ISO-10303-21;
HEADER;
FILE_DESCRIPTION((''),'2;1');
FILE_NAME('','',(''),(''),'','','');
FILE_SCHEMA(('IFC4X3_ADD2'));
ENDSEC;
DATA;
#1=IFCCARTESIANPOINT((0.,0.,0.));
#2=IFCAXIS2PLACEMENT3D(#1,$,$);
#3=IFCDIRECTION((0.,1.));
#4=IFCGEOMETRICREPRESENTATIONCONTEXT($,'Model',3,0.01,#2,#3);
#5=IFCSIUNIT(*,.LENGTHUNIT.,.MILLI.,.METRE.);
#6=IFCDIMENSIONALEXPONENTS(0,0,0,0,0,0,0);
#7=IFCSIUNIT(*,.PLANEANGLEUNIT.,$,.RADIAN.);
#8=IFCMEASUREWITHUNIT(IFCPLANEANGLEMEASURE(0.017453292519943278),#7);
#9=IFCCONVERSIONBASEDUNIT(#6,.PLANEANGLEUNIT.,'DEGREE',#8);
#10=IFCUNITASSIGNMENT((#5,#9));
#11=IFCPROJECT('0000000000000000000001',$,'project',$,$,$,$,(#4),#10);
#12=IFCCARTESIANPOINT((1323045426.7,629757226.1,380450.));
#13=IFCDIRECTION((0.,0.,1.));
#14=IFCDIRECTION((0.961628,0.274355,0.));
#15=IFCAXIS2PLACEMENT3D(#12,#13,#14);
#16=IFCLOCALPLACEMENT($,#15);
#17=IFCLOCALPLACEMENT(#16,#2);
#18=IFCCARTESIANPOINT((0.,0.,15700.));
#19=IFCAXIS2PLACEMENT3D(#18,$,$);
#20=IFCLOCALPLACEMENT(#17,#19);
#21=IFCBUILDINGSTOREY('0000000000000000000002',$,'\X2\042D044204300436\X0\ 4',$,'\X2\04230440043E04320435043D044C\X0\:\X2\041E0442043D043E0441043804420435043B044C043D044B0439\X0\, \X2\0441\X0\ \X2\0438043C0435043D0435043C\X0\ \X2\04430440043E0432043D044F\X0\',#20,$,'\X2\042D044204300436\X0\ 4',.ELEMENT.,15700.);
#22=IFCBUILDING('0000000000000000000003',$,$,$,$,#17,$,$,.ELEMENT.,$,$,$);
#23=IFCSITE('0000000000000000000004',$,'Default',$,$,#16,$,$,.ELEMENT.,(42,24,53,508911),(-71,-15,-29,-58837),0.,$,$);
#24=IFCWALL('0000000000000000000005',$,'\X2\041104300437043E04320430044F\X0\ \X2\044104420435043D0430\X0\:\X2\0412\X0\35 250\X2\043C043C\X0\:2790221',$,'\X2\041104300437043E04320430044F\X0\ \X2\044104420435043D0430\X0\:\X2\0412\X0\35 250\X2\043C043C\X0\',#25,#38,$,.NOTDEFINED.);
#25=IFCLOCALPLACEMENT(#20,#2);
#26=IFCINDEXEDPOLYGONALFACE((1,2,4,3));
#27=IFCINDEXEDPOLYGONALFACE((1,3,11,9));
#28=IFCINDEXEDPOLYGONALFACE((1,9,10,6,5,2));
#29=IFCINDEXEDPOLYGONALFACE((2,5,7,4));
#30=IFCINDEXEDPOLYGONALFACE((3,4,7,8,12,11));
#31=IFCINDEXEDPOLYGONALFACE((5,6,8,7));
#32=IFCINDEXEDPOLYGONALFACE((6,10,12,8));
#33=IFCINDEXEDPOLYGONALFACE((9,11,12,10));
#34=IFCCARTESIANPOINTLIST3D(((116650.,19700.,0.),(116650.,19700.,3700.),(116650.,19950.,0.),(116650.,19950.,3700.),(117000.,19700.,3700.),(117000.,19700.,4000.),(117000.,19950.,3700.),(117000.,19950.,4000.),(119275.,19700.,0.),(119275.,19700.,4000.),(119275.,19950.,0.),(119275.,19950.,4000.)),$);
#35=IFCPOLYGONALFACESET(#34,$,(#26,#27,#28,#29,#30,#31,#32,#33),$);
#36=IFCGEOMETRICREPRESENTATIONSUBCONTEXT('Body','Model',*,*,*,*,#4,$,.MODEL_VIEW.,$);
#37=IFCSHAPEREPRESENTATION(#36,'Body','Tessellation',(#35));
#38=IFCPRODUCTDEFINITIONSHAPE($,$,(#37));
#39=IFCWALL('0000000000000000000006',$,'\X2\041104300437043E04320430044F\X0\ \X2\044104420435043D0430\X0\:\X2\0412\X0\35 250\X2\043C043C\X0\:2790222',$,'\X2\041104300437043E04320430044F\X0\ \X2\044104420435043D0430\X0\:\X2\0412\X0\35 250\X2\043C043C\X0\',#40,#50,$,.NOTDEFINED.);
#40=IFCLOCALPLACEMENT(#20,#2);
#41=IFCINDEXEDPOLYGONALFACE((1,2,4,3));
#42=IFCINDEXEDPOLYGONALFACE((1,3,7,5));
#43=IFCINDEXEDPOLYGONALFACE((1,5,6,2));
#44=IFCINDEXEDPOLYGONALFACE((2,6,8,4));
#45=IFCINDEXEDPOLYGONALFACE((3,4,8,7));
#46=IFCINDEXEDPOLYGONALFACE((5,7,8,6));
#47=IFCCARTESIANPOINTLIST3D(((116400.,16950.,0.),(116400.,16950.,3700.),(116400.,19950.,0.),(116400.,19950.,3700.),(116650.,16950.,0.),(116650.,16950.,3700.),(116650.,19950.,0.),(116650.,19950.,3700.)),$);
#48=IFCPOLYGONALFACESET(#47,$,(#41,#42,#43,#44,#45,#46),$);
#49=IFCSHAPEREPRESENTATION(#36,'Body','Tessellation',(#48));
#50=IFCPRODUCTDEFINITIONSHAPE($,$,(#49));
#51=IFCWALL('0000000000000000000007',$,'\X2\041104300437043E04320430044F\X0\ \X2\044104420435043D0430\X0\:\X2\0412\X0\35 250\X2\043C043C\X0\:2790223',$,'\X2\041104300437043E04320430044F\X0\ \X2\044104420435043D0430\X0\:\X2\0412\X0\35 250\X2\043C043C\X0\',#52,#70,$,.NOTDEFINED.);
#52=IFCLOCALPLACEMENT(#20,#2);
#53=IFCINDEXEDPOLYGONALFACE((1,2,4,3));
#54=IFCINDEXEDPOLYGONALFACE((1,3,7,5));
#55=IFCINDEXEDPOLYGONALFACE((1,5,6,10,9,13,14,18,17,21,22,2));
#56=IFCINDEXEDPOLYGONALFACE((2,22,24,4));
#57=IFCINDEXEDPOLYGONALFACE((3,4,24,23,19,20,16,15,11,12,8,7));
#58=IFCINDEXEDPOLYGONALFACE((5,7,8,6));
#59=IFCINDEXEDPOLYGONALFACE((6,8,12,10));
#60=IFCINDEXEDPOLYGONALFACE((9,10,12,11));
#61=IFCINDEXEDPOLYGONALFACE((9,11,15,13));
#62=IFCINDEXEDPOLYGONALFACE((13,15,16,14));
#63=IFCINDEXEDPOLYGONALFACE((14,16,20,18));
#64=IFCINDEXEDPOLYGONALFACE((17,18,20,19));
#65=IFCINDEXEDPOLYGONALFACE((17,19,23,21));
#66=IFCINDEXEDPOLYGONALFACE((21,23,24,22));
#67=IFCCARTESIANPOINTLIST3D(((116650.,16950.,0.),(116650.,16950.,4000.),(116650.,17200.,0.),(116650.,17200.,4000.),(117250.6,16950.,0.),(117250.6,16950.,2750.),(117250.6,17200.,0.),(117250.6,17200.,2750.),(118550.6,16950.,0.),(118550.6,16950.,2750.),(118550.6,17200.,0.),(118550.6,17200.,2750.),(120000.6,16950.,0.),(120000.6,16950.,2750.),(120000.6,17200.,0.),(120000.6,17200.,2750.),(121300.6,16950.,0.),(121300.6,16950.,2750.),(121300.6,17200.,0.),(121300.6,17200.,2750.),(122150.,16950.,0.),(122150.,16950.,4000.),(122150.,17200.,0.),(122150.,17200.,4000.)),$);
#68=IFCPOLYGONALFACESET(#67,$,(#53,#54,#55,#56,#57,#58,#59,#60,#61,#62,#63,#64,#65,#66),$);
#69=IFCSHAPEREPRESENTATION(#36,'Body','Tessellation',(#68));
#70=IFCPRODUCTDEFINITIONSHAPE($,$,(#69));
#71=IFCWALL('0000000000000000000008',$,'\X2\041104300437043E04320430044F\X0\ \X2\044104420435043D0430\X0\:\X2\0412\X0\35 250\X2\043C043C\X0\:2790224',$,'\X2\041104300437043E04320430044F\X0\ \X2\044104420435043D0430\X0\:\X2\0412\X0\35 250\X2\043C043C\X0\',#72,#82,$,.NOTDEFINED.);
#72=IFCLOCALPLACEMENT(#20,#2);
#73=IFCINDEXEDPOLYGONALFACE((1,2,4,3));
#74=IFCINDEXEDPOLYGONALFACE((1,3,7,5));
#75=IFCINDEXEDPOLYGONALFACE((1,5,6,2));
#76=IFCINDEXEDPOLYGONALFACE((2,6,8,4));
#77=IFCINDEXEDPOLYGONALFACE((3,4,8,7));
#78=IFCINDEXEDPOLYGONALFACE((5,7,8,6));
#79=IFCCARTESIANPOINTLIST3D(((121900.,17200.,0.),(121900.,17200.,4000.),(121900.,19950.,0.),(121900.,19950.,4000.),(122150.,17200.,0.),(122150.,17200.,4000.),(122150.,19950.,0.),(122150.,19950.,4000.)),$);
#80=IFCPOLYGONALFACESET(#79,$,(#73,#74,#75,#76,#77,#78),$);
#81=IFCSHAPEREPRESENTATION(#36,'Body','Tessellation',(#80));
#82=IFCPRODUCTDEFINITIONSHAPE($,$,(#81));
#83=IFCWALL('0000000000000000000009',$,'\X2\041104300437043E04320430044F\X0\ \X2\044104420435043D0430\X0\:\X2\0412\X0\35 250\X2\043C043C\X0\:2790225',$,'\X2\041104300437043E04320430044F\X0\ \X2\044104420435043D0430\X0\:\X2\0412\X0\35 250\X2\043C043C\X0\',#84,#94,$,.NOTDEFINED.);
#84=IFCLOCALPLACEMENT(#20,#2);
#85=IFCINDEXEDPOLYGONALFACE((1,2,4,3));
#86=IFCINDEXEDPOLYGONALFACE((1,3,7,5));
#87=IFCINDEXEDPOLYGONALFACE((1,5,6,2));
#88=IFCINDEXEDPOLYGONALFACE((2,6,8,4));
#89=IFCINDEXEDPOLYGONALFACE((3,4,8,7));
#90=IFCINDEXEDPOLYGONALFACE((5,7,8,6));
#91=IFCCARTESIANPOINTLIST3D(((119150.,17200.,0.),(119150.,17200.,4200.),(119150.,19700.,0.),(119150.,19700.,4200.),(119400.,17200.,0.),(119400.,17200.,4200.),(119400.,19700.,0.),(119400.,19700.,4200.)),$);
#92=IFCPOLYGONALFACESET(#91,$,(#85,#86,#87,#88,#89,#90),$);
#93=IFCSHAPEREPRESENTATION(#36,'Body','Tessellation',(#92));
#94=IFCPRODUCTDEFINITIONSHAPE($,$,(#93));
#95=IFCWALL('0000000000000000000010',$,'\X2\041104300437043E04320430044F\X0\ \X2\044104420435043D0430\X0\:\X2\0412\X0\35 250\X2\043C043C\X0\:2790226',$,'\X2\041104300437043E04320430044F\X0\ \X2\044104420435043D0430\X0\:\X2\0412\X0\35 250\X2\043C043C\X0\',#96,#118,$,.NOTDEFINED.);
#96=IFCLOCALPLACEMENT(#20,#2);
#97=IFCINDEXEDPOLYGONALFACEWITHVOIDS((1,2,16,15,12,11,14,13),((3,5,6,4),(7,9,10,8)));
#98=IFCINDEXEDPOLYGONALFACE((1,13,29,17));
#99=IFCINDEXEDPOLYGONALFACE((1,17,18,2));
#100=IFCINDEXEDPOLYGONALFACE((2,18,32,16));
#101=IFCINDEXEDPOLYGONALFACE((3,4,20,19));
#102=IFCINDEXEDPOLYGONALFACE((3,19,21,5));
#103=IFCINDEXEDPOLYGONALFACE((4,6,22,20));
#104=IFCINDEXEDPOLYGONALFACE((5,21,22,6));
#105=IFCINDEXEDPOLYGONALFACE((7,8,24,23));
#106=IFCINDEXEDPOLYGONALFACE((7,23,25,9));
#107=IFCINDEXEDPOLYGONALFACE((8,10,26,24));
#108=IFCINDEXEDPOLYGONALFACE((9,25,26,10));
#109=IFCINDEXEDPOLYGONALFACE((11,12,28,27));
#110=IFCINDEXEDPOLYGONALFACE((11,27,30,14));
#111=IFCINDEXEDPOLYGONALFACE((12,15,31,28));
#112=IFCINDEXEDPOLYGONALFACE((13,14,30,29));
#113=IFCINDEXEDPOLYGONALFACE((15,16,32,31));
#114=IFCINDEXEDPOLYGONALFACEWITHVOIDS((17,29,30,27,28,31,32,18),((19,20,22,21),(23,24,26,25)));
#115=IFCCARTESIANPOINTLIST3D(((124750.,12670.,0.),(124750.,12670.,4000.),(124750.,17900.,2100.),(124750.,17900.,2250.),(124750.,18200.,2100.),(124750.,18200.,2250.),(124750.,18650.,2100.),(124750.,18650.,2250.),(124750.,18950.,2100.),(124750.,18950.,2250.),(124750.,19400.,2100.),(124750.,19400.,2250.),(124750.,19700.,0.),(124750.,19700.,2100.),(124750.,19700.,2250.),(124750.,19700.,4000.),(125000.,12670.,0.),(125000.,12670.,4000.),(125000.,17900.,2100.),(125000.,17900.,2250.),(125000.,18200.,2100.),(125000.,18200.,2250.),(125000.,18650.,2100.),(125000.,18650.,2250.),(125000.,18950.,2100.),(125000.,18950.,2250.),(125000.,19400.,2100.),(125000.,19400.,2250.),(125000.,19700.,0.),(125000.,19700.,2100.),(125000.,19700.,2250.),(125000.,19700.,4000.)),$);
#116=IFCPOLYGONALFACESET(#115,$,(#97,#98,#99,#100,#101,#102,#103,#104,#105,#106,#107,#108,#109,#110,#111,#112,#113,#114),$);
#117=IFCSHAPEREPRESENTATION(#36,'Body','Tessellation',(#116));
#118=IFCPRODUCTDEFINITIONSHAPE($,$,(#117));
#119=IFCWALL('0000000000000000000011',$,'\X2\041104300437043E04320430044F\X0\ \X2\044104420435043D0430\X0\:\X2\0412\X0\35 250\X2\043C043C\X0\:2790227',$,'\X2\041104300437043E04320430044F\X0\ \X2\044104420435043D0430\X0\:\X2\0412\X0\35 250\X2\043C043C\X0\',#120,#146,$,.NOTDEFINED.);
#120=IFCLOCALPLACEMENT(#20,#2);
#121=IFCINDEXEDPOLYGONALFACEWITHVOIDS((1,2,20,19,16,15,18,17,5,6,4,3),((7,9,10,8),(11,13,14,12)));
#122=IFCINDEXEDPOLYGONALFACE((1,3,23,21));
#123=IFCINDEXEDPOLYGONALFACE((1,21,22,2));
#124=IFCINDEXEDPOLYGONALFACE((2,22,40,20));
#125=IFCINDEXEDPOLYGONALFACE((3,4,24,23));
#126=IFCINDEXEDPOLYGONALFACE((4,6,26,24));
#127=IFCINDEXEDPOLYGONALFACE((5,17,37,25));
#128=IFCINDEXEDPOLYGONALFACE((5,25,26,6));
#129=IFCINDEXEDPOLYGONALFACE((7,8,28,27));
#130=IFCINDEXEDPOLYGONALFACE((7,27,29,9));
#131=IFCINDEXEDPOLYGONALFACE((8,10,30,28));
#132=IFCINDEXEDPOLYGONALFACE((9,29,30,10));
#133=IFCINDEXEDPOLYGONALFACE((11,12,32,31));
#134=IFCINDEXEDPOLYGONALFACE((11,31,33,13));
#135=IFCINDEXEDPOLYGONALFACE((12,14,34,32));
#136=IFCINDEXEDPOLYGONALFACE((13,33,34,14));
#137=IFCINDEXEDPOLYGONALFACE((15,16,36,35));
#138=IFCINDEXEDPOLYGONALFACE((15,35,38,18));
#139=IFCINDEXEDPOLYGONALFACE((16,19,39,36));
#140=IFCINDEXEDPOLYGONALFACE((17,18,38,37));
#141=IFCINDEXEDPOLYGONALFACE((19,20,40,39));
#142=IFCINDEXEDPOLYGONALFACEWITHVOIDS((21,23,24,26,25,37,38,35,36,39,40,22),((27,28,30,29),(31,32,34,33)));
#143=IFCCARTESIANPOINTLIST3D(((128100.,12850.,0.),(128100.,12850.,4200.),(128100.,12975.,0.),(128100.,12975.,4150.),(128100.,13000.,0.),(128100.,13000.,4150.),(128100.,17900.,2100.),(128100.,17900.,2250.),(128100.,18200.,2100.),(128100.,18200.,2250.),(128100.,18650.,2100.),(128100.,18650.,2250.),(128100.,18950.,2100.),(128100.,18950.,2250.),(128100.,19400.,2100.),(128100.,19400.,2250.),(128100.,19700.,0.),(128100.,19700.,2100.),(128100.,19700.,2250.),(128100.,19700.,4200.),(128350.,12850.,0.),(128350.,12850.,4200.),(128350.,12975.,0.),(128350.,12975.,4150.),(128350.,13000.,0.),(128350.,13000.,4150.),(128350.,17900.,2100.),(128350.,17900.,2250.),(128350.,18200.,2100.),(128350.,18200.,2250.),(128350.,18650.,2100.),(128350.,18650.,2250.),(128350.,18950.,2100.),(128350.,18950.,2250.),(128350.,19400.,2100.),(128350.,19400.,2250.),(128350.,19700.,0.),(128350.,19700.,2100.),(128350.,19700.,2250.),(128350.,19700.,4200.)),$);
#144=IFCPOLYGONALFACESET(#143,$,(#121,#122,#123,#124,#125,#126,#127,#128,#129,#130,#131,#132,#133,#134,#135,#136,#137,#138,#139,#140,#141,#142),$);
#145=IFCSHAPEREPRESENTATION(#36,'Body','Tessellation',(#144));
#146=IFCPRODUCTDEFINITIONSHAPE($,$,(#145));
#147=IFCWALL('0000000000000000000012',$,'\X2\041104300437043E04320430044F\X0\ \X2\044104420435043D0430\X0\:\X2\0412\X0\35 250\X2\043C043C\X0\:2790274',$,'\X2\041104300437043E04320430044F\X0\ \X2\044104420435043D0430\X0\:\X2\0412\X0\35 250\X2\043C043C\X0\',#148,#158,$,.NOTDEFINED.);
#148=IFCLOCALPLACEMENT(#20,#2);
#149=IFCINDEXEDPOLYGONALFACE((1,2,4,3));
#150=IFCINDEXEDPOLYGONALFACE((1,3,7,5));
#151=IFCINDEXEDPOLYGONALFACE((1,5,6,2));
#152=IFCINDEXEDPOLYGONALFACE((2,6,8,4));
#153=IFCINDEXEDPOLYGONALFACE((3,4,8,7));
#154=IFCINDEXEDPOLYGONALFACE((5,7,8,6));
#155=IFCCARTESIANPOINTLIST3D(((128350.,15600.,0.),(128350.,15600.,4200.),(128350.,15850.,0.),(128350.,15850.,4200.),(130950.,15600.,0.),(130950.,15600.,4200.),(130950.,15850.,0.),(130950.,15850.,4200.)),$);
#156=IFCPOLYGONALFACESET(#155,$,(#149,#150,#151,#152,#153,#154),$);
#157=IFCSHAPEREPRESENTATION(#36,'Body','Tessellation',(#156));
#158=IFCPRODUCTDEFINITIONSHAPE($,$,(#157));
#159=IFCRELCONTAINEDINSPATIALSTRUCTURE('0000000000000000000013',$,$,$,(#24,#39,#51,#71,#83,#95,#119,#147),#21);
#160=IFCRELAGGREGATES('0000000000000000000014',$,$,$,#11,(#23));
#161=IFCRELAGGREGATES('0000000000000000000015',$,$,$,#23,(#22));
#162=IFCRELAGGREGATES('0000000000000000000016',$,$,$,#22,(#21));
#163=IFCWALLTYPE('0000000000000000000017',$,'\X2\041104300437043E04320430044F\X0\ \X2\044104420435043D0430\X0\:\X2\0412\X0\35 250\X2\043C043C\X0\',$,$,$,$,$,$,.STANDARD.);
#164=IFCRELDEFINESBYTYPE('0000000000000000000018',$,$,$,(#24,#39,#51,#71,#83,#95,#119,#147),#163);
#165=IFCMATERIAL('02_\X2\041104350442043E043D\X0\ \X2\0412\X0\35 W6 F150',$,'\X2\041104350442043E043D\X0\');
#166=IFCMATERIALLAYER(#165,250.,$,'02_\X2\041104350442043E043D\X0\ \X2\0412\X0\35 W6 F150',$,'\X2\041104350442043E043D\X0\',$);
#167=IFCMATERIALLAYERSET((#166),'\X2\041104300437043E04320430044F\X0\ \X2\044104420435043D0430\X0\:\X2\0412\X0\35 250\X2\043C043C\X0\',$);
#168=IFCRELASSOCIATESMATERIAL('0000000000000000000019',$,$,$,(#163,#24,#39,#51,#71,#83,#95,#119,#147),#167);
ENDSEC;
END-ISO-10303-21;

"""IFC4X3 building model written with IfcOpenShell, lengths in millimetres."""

from ifc_helpers import new_model, entity, si_unit, converted_unit, direction, frame, frame_2d, origin, place, context, subcontext, project, spatial, rectangle, extrude, material, layer, layer_set, type_object, element, save


model = new_model("IFC4X3")

# Units and contexts
model_context = context("Model", 3, precision=0.01, world=origin(), true_north=direction((0.0, 1.0)))
body_context = subcontext(model_context, "Body", "Model", "MODEL_VIEW")
ifc_project = project(units=[si_unit("LENGTHUNIT", "METRE", prefix="MILLI"), converted_unit("PLANEANGLEUNIT", "DEGREE", entity("IfcPlaneAngleMeasure", 0.017453292519943278), si_unit("PLANEANGLEUNIT", "RADIAN"), dimensions=[0, 0, 0, 0, 0, 0, 0])], contexts=[model_context])

# Site, building, storey
site_placement = place(None, frame((1323045426.7, 629757226.1, 380450.0), z_axis=(0.0, 0.0, 1.0), x_axis=(0.961628, 0.274355, 0.0)))
site = spatial("IfcSite", under=ifc_project, at=site_placement, Name="Default", CompositionType="ELEMENT", RefLatitude=(42, 24, 53, 508911), RefLongitude=(-71, -15, -29, -58837), RefElevation=0.0)
building_placement = place(site_placement, origin())
building = spatial("IfcBuilding", under=site, at=building_placement, CompositionType="ELEMENT")
storey_placement = place(building_placement, frame((0.0, 0.0, 15700.0)))
storey = spatial("IfcBuildingStorey", under=building, at=storey_placement, Name="Этаж 4", ObjectType="Уровень:Относительный, с именем уровня", LongName="Этаж 4", CompositionType="ELEMENT", Elevation=15700.0)

# Wall, opening
ifc_material = material(Name="02_Бетон В35 W6 F150", Category="Бетон")
ifc_layer_1 = layer(ifc_material, 250.0, Name="02_Бетон В35 W6 F150", Category="Бетон")
ifc_layer_set_1 = layer_set([ifc_layer_1], Name="Базовая стена:В35 250мм")
wall_type_1 = type_object("IfcWallType", Name="Базовая стена:В35 250мм", PredefinedType="STANDARD", material=ifc_layer_set_1)
wall_1_placement = place(storey_placement, frame((116650.0, 19825.0, 0.0)))
wall_1 = element("IfcWall", 1, at=wall_1_placement, inside=storey, type_object=wall_type_1, material=ifc_layer_set_1, Name="Базовая стена:В35 250мм:2790221", ObjectType="Базовая стена:В35 250мм", PredefinedType="NOTDEFINED", context=body_context, shape_type="SweptSolid", body=[
    extrude(rectangle(XDim=2625.0, YDim=250.0, at=frame_2d((1312.5, 0.0), x_axis=(-1.0, 0.0))), origin(), (0.0, 0.0, 1.0), 4000.0),
])
opening_1_placement = place(wall_1_placement, origin())
element("IfcOpeningElement", 2, at=opening_1_placement, cuts=wall_1, PredefinedType="OPENING", context=body_context, shape_type="SweptSolid", body=[
    extrude(rectangle(XDim=300.0, YDim=350.0, at=frame_2d((0.0, 0.0), x_axis=(0.0, 1.0))), frame((175.0, 125.0, 3850.0), z_axis=(0.0, -1.0, 0.0), x_axis=(-1.0, 0.0, 0.0)), (0.0, 0.0, 1.0), 250.0),
])

# Wall
wall_2_placement = place(storey_placement, frame((116525.0, 16950.0, 0.0), z_axis=(0.0, 0.0, 1.0), x_axis=(0.0, 1.0, 0.0)))
element("IfcWall", 3, at=wall_2_placement, inside=storey, type_object=wall_type_1, material=ifc_layer_set_1, Name="Базовая стена:В35 250мм:2790222", ObjectType="Базовая стена:В35 250мм", PredefinedType="NOTDEFINED", context=body_context, shape_type="SweptSolid", body=[
    extrude(rectangle(XDim=3000.0, YDim=250.0, at=frame_2d((1500.0, 0.0), x_axis=(-1.0, 0.0))), origin(), (0.0, 0.0, 1.0), 3700.0),
])

# Wall, openings
wall_3_placement = place(storey_placement, frame((116650.0, 17075.0, 0.0)))
wall_3 = element("IfcWall", 4, at=wall_3_placement, inside=storey, type_object=wall_type_1, material=ifc_layer_set_1, Name="Базовая стена:В35 250мм:2790223", ObjectType="Базовая стена:В35 250мм", PredefinedType="NOTDEFINED", context=body_context, shape_type="SweptSolid", body=[
    extrude(rectangle(XDim=5500.0, YDim=250.0, at=frame_2d((2750.0, 0.0), x_axis=(-1.0, 0.0))), origin(), (0.0, 0.0, 1.0), 4000.0),
])
opening_2_placement = place(wall_3_placement, frame((-116650.0, -17075.0, 0.0)))
element("IfcOpeningElement", 5, at=opening_2_placement, cuts=wall_3, PredefinedType="OPENING", context=body_context, shape_type="SweptSolid", body=[
    extrude(rectangle(XDim=2750.0, YDim=1300.0, at=frame_2d((0.0, 0.0), x_axis=(1.0, 0.0))), frame((117900.6, 15426.0, 1375.0), z_axis=(0.0, 1.0, 0.0), x_axis=(0.0, 0.0, -1.0)), (0.0, 0.0, 1.0), 3048.0),
])
opening_3_placement = place(wall_3_placement, frame((-116650.0, -17075.0, 0.0)))
element("IfcOpeningElement", 6, at=opening_3_placement, cuts=wall_3, PredefinedType="OPENING", context=body_context, shape_type="SweptSolid", body=[
    extrude(rectangle(XDim=2750.0, YDim=1300.0, at=frame_2d((0.0, 0.0), x_axis=(1.0, 0.0))), frame((120650.6, 15426.0, 1375.0), z_axis=(0.0, 1.0, 0.0), x_axis=(0.0, 0.0, -1.0)), (0.0, 0.0, 1.0), 3048.0),
])

# Walls
wall_4_placement = place(storey_placement, frame((122025.0, 17200.0, 0.0), z_axis=(0.0, 0.0, 1.0), x_axis=(0.0, 1.0, 0.0)))
element("IfcWall", 7, at=wall_4_placement, inside=storey, type_object=wall_type_1, material=ifc_layer_set_1, Name="Базовая стена:В35 250мм:2790224", ObjectType="Базовая стена:В35 250мм", PredefinedType="NOTDEFINED", context=body_context, shape_type="SweptSolid", body=[
    extrude(rectangle(XDim=2750.0, YDim=250.0, at=frame_2d((1375.0, 0.0), x_axis=(-1.0, 0.0))), origin(), (0.0, 0.0, 1.0), 4000.0),
])
wall_5_placement = place(storey_placement, frame((119275.0, 17200.0, 0.0), z_axis=(0.0, 0.0, 1.0), x_axis=(0.0, 1.0, 0.0)))
element("IfcWall", 8, at=wall_5_placement, inside=storey, type_object=wall_type_1, material=ifc_layer_set_1, Name="Базовая стена:В35 250мм:2790225", ObjectType="Базовая стена:В35 250мм", PredefinedType="NOTDEFINED", context=body_context, shape_type="SweptSolid", body=[
    extrude(rectangle(XDim=2500.0, YDim=250.0, at=frame_2d((1250.0, 0.0), x_axis=(-1.0, 0.0))), origin(), (0.0, 0.0, 1.0), 4200.0),
])

# Walls, openings
wall_6_placement = place(storey_placement, frame((124875.0, 19700.0, 0.0), z_axis=(0.0, 0.0, 1.0), x_axis=(0.0, -1.0, 0.0)))
wall_6 = element("IfcWall", 9, at=wall_6_placement, inside=storey, type_object=wall_type_1, material=ifc_layer_set_1, Name="Базовая стена:В35 250мм:2790226", ObjectType="Базовая стена:В35 250мм", PredefinedType="NOTDEFINED", context=body_context, shape_type="SweptSolid", body=[
    extrude(rectangle(XDim=7030.0, YDim=250.0, at=frame_2d((3515.0, 0.0), x_axis=(-1.0, 0.0))), origin(), (0.0, 0.0, 1.0), 4000.0),
])
opening_4_placement = place(wall_6_placement, frame((19700.0, -124875.0, 2100.0), z_axis=(0.0, 0.0, 1.0), x_axis=(0.0, 1.0, 0.0)))
element("IfcOpeningElement", 10, at=opening_4_placement, cuts=wall_6, PredefinedType="OPENING", context=body_context, shape_type="SweptSolid", body=[
    extrude(rectangle(XDim=150.0, YDim=300.0, at=frame_2d((0.0, 0.0), x_axis=(0.0, 1.0))), frame((123226.0, 19550.0, 75.0), z_axis=(1.0, 0.0, 0.0), x_axis=(0.0, -1.0, 0.0)), (0.0, 0.0, 1.0), 3048.0),
])
opening_5_placement = place(wall_6_placement, frame((19700.0, -124875.0, 2100.0), z_axis=(0.0, 0.0, 1.0), x_axis=(0.0, 1.0, 0.0)))
element("IfcOpeningElement", 11, at=opening_5_placement, cuts=wall_6, PredefinedType="OPENING", context=body_context, shape_type="SweptSolid", body=[
    extrude(rectangle(XDim=150.0, YDim=300.0, at=frame_2d((0.0, 0.0), x_axis=(0.0, 1.0))), frame((123226.0, 18800.0, 75.0), z_axis=(1.0, 0.0, 0.0), x_axis=(0.0, -1.0, 0.0)), (0.0, 0.0, 1.0), 3048.0),
])
opening_6_placement = place(wall_6_placement, frame((19700.0, -124875.0, 2100.0), z_axis=(0.0, 0.0, 1.0), x_axis=(0.0, 1.0, 0.0)))
element("IfcOpeningElement", 12, at=opening_6_placement, cuts=wall_6, PredefinedType="OPENING", context=body_context, shape_type="SweptSolid", body=[
    extrude(rectangle(XDim=150.0, YDim=300.0, at=frame_2d((0.0, 0.0), x_axis=(0.0, 1.0))), frame((123226.0, 18050.0, 75.0), z_axis=(1.0, 0.0, 0.0), x_axis=(0.0, -1.0, 0.0)), (0.0, 0.0, 1.0), 3048.0),
])
wall_7_placement = place(storey_placement, frame((128225.0, 19700.0, 0.0), z_axis=(0.0, 0.0, 1.0), x_axis=(0.0, -1.0, 0.0)))
wall_7 = element("IfcWall", 13, at=wall_7_placement, inside=storey, type_object=wall_type_1, material=ifc_layer_set_1, Name="Базовая стена:В35 250мм:2790227", ObjectType="Базовая стена:В35 250мм", PredefinedType="NOTDEFINED", context=body_context, shape_type="SweptSolid", body=[
    extrude(rectangle(XDim=6850.0, YDim=250.0, at=frame_2d((3425.0, 0.0), x_axis=(-1.0, 0.0))), origin(), (0.0, 0.0, 1.0), 4200.0),
])
opening_7_placement = place(wall_7_placement, origin())
element("IfcOpeningElement", 14, at=opening_7_placement, cuts=wall_7, PredefinedType="OPENING", context=body_context, shape_type="SweptSolid", body=[
    extrude(rectangle(XDim=4150.0, YDim=25.0, at=frame_2d((0.0, 0.0), x_axis=(0.0, 1.0))), frame((6712.5, 125.0, 2075.0), z_axis=(0.0, -1.0, 0.0), x_axis=(1.0, 0.0, 0.0)), (0.0, 0.0, 1.0), 250.0),
])
opening_8_placement = place(wall_7_placement, frame((19700.0, -128225.0, 2100.0), z_axis=(0.0, 0.0, 1.0), x_axis=(0.0, 1.0, 0.0)))
element("IfcOpeningElement", 15, at=opening_8_placement, cuts=wall_7, PredefinedType="OPENING", context=body_context, shape_type="SweptSolid", body=[
    extrude(rectangle(XDim=150.0, YDim=300.0, at=frame_2d((0.0, 0.0), x_axis=(1.0, 0.0))), frame((126826.0, 19550.0, 75.0), z_axis=(1.0, 0.0, 0.0), x_axis=(0.0, 0.0, -1.0)), (0.0, 0.0, 1.0), 3048.0),
])
opening_9_placement = place(wall_7_placement, frame((19700.0, -128225.0, 2100.0), z_axis=(0.0, 0.0, 1.0), x_axis=(0.0, 1.0, 0.0)))
element("IfcOpeningElement", 16, at=opening_9_placement, cuts=wall_7, PredefinedType="OPENING", context=body_context, shape_type="SweptSolid", body=[
    extrude(rectangle(XDim=150.0, YDim=300.0, at=frame_2d((0.0, 0.0), x_axis=(1.0, 0.0))), frame((126826.0, 18800.0, 75.0), z_axis=(1.0, 0.0, 0.0), x_axis=(0.0, 0.0, -1.0)), (0.0, 0.0, 1.0), 3048.0),
])
opening_10_placement = place(wall_7_placement, frame((19700.0, -128225.0, 2100.0), z_axis=(0.0, 0.0, 1.0), x_axis=(0.0, 1.0, 0.0)))
element("IfcOpeningElement", 17, at=opening_10_placement, cuts=wall_7, PredefinedType="OPENING", context=body_context, shape_type="SweptSolid", body=[
    extrude(rectangle(XDim=150.0, YDim=300.0, at=frame_2d((0.0, 0.0), x_axis=(1.0, 0.0))), frame((126826.0, 18050.0, 75.0), z_axis=(1.0, 0.0, 0.0), x_axis=(0.0, 0.0, -1.0)), (0.0, 0.0, 1.0), 3048.0),
])

# Wall
for number, where, z_axis, x_axis, name in (
    (18, (130950.0, 15725.0, 0.0), (0.0, 0.0, 1.0), (-1.0, 0.0, 0.0), "Базовая стена:В35 250мм:2790274"),
):
    element("IfcWall", number, at=place(storey_placement, frame(where, z_axis=z_axis, x_axis=x_axis)), inside=storey, type_object=wall_type_1, material=ifc_layer_set_1, Name=name, ObjectType="Базовая стена:В35 250мм", PredefinedType="NOTDEFINED", context=body_context, shape_type="SweptSolid", body=[
        extrude(rectangle(XDim=2600.0, YDim=250.0, at=frame_2d((1300.0, 0.0), x_axis=(-1.0, 0.0))), origin(), (0.0, 0.0, 1.0), 4200.0),
    ])

save(model, "model.ifc")
